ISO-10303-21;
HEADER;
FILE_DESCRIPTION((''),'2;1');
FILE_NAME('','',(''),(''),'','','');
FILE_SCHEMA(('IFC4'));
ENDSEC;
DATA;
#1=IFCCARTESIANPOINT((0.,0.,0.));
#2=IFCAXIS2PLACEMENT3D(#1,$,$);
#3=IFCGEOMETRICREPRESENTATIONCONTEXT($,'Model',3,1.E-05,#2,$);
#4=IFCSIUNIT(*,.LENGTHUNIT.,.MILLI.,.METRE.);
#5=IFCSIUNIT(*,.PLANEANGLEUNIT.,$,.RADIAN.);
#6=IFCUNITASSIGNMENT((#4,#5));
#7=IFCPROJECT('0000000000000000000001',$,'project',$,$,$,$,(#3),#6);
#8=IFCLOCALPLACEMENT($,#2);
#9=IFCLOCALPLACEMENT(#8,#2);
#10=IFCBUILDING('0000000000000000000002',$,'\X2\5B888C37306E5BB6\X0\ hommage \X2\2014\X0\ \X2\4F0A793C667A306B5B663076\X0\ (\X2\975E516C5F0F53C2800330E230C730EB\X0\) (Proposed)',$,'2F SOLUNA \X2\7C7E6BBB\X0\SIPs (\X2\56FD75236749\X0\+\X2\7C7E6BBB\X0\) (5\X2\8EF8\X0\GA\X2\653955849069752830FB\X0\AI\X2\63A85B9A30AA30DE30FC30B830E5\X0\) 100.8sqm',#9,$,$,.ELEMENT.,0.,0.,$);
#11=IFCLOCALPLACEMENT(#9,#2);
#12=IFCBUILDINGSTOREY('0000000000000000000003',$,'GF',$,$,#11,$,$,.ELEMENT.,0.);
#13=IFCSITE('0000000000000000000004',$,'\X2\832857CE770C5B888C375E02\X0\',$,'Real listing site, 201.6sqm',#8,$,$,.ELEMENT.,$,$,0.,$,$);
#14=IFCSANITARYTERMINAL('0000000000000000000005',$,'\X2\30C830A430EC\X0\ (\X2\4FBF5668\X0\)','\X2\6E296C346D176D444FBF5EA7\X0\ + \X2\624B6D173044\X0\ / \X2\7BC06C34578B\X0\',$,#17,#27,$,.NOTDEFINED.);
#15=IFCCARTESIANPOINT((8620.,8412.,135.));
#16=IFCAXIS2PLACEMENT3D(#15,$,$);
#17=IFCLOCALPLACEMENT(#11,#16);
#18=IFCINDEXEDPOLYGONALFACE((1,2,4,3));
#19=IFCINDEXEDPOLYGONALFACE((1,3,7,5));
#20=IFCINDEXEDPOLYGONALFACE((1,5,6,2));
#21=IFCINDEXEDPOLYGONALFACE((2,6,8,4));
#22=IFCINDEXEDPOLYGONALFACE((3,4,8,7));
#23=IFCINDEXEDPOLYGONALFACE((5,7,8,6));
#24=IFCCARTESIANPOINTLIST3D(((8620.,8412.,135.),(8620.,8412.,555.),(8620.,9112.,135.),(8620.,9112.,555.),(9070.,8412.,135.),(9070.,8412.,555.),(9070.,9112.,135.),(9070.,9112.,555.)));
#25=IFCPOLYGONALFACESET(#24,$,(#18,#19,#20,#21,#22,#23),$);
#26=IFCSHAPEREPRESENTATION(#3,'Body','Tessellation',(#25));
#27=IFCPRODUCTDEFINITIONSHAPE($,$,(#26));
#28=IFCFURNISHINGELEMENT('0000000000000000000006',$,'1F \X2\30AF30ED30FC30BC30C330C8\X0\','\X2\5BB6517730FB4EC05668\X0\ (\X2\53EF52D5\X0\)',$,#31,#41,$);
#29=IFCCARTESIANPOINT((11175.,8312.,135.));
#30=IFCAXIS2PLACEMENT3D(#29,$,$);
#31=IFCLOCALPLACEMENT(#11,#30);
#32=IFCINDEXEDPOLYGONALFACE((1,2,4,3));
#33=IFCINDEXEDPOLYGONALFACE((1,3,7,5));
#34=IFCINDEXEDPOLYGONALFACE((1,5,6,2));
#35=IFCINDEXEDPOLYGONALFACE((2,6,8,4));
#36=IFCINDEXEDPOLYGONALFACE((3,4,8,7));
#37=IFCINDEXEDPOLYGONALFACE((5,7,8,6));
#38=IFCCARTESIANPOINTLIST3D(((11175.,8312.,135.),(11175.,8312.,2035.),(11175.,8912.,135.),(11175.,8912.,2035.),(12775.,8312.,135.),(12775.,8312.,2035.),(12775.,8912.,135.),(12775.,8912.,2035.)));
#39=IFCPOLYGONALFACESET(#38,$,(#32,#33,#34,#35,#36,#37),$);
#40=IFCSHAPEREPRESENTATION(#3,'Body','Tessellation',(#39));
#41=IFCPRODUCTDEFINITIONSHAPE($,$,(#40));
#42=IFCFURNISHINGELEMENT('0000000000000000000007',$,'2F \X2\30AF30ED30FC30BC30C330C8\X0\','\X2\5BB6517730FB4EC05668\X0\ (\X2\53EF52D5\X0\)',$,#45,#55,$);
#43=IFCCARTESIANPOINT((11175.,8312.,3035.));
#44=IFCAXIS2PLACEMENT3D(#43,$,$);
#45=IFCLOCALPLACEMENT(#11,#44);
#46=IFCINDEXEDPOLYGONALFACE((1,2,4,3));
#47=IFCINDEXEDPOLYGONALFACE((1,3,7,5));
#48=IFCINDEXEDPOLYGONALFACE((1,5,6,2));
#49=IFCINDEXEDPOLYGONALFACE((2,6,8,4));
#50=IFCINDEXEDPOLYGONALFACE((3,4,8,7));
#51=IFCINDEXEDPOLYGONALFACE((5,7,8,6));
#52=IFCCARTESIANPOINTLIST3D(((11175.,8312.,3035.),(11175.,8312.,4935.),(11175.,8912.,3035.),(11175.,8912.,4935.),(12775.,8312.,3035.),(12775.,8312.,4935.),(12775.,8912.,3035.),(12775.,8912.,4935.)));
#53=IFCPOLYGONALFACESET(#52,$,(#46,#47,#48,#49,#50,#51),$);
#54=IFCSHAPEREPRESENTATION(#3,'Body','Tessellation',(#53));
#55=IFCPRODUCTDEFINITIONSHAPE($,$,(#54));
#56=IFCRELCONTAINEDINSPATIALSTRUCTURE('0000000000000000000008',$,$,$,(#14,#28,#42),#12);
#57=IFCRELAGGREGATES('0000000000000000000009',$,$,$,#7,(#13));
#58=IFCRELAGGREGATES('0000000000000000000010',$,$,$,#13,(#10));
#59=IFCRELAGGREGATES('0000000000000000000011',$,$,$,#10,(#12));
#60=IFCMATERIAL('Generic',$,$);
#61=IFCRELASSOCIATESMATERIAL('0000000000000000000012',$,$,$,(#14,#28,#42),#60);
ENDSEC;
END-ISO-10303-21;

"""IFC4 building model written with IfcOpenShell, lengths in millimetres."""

from ifc_helpers import new_model, si_unit, frame, frame_2d, origin, place, context, project, spatial, rectangle, extrude, material, element, save


model = new_model("IFC4")

# Units and contexts
model_context = context("Model", 3, precision=1e-05, world=origin())
ifc_project = project(units=[si_unit("LENGTHUNIT", "METRE", prefix="MILLI"), si_unit("PLANEANGLEUNIT", "RADIAN")], contexts=[model_context])

# Site, building, storey
site_placement = place(None, origin())
site = spatial("IfcSite", under=ifc_project, at=site_placement, Name="茨城県守谷市", ObjectType="Real listing site, 201.6sqm", CompositionType="ELEMENT", RefElevation=0.0)
building_placement = place(site_placement, origin())
building = spatial("IfcBuilding", under=site, at=building_placement, Name="守谷の家 hommage — 伊礼智に学ぶ (非公式参考モデル) (Proposed)", ObjectType="2F SOLUNA 籾殻SIPs (国産杉+籾殻) (5軸GA改善適用・AI推定オマージュ) 100.8sqm", CompositionType="ELEMENT", ElevationOfRefHeight=0.0, ElevationOfTerrain=0.0)
storey_placement = place(building_placement, origin())
storey = spatial("IfcBuildingStorey", under=building, at=storey_placement, Name="GF", CompositionType="ELEMENT", Elevation=0.0)

# Shared definitions
ifc_material_1 = material(Name="Generic")

# Sanitary terminal
sanitary_terminal_1_placement = place(storey_placement, frame((8620.0, 8412.0, 135.0)))
element("IfcSanitaryTerminal", 1, at=sanitary_terminal_1_placement, inside=storey, material=ifc_material_1, Name="トイレ (便器)", Description="温水洗浄便座 + 手洗い / 節水型", PredefinedType="NOTDEFINED", context=model_context, shape_type="SweptSolid", body=[
    extrude(rectangle(XDim=450.0, YDim=700.0, at=frame_2d((225.0, 350.0))), frame((8620.0, 8412.0, 135.0)), (0.0, 0.0, 1.0), 420.0),
])

# Furnishing elements
furnishing_1_placement = place(storey_placement, frame((11175.0, 8312.0, 135.0)))
element("IfcFurnishingElement", 2, at=furnishing_1_placement, inside=storey, material=ifc_material_1, Name="1F クローゼット", Description="家具・什器 (可動)", context=model_context, shape_type="SweptSolid", body=[
    extrude(rectangle(XDim=1600.0, YDim=600.0, at=frame_2d((800.0, 300.0))), frame((11175.0, 8312.0, 135.0)), (0.0, 0.0, 1.0), 1900.0),
])
furnishing_2_placement = place(storey_placement, frame((11175.0, 8312.0, 3035.0)))
element("IfcFurnishingElement", 3, at=furnishing_2_placement, inside=storey, material=ifc_material_1, Name="2F クローゼット", Description="家具・什器 (可動)", context=model_context, shape_type="SweptSolid", body=[
    extrude(rectangle(XDim=1600.0, YDim=600.0, at=frame_2d((800.0, 300.0))), frame((11175.0, 8312.0, 3035.0)), (0.0, 0.0, 1.0), 1900.0),
])

save(model, "model.ifc")
